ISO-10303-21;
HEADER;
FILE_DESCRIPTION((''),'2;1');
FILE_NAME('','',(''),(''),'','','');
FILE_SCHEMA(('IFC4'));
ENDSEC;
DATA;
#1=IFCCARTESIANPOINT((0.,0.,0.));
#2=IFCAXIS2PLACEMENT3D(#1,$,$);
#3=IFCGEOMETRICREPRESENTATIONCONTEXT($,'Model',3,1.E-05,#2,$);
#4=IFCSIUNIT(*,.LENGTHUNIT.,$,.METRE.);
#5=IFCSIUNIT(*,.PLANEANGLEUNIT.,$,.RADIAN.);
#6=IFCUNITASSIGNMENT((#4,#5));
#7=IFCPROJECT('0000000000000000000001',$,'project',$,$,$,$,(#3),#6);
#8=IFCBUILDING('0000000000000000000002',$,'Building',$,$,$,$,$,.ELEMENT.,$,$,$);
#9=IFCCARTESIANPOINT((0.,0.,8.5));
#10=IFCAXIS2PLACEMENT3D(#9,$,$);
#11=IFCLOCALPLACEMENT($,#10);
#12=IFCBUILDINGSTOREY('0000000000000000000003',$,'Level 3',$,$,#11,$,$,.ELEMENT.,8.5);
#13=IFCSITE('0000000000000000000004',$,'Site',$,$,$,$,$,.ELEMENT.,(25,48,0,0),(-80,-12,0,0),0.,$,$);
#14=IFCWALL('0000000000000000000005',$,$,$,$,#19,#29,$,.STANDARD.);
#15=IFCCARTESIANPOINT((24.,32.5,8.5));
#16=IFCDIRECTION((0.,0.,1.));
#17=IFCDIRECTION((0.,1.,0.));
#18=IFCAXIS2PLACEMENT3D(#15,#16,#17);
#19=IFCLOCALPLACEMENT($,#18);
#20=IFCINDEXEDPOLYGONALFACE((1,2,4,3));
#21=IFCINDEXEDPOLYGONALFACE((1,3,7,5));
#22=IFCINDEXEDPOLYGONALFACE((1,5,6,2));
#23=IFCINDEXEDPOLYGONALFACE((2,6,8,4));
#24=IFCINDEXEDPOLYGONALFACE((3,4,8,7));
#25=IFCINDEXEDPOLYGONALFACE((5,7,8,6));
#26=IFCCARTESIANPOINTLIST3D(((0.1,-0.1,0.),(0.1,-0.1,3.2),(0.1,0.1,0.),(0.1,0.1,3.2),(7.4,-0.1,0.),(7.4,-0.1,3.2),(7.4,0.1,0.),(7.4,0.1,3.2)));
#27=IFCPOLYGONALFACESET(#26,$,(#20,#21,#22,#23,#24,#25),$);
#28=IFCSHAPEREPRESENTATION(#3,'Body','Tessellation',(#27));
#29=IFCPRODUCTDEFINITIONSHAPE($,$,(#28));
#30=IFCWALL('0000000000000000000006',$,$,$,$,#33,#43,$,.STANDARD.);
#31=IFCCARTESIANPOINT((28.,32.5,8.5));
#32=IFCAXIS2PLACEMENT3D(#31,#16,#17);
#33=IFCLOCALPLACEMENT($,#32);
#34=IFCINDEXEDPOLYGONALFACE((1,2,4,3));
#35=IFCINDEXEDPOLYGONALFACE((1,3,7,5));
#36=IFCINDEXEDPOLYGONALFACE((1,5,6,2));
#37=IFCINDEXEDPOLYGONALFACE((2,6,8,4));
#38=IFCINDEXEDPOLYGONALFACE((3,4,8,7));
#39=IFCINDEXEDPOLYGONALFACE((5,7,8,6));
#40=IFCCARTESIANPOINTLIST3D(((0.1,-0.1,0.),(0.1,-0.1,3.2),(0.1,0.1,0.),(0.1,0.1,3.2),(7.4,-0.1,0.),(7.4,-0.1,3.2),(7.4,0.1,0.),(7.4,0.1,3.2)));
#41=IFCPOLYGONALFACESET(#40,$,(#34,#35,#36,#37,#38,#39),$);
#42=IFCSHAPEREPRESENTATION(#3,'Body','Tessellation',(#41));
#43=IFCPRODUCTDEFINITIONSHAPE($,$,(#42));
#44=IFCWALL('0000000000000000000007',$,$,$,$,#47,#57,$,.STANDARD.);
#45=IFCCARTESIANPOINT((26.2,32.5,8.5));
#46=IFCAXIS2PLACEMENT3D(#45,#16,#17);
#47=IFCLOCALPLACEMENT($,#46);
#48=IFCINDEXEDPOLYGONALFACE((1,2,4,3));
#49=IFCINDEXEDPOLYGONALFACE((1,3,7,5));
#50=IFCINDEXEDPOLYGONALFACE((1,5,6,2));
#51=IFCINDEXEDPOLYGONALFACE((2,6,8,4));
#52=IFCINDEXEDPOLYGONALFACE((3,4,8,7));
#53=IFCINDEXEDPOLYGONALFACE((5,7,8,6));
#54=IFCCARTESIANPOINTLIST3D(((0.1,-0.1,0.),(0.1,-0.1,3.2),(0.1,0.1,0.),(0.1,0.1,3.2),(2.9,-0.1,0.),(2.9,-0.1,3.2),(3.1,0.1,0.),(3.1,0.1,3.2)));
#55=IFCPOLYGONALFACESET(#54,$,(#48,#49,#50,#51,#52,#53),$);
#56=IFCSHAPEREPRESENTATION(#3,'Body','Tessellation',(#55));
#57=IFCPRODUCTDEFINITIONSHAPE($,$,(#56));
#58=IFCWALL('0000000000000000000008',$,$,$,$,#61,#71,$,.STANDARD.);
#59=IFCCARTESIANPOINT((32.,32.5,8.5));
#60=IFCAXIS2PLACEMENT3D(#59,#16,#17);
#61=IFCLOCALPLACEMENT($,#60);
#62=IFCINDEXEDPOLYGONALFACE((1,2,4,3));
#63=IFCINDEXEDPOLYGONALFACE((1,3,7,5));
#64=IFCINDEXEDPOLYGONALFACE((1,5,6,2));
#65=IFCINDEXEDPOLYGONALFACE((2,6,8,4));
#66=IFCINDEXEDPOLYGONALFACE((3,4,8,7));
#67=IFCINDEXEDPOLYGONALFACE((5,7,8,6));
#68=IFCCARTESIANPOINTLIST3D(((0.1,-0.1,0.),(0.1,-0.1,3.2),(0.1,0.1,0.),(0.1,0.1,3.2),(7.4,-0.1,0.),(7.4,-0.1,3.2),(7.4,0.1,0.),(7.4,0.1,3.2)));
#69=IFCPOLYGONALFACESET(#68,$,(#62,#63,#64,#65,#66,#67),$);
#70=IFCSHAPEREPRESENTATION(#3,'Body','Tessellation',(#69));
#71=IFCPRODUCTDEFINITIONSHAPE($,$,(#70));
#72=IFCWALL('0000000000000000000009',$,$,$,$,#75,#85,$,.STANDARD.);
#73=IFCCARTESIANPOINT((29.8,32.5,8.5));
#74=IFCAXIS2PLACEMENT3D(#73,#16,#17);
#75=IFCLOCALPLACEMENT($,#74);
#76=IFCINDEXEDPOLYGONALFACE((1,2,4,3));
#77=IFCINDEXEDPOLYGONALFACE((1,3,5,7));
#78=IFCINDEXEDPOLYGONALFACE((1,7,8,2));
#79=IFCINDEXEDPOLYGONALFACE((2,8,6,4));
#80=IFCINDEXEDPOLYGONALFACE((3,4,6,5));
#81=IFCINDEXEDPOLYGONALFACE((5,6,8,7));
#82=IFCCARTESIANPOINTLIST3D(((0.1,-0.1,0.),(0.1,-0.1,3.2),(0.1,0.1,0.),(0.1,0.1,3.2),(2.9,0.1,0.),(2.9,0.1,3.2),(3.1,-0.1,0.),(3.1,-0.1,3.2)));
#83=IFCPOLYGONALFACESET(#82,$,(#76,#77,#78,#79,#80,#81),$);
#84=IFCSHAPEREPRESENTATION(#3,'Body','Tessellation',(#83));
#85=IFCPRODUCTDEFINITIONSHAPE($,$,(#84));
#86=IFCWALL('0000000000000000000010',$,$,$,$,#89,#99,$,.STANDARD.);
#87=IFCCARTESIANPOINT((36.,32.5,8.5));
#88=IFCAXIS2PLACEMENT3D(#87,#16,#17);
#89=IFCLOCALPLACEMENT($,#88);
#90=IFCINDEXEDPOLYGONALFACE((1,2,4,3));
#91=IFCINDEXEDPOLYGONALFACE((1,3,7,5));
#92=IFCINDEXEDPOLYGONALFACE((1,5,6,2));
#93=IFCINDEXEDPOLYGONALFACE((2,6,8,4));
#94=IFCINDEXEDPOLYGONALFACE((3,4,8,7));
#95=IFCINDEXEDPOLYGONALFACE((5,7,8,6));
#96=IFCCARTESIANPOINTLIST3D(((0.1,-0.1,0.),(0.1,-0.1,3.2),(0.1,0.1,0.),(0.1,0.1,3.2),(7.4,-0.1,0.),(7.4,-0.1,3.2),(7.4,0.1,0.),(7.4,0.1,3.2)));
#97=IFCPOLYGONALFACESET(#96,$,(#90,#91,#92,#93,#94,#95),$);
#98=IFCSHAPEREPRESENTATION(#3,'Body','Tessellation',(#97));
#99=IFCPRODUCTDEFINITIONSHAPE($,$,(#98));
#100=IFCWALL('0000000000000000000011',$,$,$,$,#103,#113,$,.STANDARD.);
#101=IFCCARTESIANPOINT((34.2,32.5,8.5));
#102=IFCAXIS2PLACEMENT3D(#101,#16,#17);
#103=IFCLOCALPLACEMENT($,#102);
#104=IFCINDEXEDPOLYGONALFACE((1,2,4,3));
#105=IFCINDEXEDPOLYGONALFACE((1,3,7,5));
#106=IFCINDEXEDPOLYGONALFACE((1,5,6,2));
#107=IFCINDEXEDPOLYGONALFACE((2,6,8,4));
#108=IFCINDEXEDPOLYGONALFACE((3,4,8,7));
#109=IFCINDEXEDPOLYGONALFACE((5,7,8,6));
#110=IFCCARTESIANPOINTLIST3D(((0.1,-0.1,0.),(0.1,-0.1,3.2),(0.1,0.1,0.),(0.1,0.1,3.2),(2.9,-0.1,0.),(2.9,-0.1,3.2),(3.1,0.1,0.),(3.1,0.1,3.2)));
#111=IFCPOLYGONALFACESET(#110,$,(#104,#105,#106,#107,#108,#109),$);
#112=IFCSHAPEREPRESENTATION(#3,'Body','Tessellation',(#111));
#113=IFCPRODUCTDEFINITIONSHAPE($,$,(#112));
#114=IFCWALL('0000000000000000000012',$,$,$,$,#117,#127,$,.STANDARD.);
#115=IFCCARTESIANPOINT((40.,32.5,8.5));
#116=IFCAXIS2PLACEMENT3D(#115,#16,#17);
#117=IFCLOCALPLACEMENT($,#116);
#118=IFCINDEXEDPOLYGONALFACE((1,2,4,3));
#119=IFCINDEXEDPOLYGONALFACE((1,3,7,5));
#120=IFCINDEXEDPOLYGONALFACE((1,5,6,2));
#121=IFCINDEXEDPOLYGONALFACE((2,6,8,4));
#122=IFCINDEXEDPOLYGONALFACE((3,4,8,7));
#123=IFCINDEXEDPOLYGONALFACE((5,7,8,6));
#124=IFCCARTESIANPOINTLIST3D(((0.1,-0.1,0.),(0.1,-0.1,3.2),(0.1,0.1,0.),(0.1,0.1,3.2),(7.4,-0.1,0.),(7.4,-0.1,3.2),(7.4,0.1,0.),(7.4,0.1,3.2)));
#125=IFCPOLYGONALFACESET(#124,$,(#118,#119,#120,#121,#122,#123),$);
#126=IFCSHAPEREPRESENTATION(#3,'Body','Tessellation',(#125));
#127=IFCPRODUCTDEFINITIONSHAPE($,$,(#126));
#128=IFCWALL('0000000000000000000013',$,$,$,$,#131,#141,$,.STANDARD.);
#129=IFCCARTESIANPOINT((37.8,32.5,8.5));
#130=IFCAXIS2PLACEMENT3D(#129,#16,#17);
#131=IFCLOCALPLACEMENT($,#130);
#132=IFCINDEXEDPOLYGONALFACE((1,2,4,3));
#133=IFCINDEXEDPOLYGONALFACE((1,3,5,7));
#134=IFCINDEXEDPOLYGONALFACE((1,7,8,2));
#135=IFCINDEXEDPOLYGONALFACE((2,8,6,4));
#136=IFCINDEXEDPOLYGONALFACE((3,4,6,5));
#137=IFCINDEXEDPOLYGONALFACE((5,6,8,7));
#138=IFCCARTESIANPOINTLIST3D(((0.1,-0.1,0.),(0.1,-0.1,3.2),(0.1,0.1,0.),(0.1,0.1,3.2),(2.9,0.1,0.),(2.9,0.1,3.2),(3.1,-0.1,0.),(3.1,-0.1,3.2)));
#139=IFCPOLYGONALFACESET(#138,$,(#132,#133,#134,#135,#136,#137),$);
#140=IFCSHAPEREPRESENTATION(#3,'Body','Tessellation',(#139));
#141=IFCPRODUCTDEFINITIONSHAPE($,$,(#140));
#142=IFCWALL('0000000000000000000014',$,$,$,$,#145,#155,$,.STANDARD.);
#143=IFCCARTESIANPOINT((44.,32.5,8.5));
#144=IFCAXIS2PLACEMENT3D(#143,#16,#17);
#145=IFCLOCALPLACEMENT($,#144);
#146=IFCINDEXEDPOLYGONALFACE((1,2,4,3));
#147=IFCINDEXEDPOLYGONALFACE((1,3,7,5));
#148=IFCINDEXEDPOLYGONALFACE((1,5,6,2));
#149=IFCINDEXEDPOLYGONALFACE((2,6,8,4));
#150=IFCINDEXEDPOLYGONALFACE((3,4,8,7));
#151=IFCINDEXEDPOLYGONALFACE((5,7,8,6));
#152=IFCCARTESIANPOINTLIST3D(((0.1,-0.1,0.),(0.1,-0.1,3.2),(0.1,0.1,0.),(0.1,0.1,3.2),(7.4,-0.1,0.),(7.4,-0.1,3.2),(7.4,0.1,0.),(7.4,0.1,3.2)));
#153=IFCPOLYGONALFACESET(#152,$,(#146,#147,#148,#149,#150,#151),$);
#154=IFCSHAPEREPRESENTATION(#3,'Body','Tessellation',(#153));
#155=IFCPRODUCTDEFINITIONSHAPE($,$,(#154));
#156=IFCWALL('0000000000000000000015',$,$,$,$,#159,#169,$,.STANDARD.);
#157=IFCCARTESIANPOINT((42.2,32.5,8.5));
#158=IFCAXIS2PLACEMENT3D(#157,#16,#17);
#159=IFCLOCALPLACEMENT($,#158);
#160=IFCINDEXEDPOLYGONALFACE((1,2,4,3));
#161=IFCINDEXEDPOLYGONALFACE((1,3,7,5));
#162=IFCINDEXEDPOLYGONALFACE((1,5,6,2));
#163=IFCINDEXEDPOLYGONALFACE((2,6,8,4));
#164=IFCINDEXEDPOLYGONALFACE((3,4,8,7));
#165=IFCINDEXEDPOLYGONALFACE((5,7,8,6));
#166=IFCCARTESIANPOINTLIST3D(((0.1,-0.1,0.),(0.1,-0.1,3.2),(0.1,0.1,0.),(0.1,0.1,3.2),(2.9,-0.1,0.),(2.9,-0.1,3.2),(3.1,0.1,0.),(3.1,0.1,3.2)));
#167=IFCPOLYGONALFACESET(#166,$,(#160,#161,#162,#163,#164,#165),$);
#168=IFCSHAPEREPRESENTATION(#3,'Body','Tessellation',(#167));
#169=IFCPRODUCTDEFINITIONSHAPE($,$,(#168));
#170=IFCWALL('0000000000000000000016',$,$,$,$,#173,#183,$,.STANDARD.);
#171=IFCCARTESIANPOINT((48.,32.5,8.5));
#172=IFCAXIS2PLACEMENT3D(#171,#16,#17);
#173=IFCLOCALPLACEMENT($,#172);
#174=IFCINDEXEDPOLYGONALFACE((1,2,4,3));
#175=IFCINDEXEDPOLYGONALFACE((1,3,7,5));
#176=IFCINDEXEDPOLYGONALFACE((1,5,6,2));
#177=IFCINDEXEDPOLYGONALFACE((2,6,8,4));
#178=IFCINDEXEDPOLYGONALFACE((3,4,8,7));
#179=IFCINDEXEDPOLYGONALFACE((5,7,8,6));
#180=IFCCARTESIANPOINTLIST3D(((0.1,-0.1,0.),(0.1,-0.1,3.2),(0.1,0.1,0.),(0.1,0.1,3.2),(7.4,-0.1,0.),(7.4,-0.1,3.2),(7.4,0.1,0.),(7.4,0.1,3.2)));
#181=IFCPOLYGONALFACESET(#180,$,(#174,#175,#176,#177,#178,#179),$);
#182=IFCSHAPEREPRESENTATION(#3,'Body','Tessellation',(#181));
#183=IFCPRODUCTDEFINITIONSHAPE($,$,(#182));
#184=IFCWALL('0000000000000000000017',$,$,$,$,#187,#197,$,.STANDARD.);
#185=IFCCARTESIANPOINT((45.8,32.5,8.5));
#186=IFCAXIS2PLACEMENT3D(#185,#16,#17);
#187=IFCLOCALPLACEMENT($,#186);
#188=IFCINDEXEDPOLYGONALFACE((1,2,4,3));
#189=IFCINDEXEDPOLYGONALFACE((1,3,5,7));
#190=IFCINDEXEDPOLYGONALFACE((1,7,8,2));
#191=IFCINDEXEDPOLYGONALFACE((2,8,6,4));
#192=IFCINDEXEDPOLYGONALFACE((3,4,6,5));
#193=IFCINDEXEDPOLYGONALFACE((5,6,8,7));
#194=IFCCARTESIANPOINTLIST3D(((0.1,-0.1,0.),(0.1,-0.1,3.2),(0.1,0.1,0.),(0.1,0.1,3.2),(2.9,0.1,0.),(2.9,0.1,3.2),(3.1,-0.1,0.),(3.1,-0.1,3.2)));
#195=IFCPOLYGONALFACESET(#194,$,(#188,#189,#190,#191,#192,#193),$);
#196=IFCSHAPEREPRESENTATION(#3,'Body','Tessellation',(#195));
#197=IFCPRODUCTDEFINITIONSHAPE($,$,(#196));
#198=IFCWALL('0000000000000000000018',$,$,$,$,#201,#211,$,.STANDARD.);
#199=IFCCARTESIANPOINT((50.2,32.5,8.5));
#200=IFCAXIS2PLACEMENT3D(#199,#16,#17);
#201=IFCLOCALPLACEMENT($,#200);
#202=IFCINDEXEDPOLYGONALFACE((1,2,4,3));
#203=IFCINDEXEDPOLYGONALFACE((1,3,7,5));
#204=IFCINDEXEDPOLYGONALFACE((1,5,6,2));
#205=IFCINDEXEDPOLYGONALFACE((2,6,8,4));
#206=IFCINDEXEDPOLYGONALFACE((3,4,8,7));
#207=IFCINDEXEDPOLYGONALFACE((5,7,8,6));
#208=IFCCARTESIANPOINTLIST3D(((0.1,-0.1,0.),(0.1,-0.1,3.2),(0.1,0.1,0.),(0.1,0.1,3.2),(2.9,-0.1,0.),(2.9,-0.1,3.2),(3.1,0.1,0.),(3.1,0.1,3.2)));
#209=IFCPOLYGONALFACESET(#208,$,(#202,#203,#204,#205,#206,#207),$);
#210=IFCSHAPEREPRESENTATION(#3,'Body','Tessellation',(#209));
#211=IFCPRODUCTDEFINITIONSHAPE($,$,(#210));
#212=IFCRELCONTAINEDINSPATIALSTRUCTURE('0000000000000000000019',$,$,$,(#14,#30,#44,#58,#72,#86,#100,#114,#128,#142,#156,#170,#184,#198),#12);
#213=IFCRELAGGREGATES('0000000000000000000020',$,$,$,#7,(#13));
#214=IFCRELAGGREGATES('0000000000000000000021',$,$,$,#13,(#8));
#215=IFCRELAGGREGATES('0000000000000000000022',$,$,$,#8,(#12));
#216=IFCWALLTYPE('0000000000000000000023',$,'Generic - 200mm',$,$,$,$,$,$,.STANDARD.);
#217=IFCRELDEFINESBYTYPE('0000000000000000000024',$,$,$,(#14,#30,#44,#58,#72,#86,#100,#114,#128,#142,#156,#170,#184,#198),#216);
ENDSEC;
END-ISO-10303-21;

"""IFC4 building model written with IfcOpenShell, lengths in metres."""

from ifc_helpers import new_model, si_unit, frame, origin, place, context, project, spatial, polyline, outline, extrude, type_object, element, save


model = new_model("IFC4")

# Units and contexts
model_context = context("Model", 3, precision=1e-05, world=origin())
ifc_project = project(units=[si_unit("LENGTHUNIT", "METRE"), si_unit("PLANEANGLEUNIT", "RADIAN")], contexts=[model_context])

# Site, building, storey
site = spatial("IfcSite", under=ifc_project, Name="Site", CompositionType="ELEMENT", RefLatitude=(25, 48, 0, 0), RefLongitude=(-80, -12, 0, 0), RefElevation=0.0)
building = spatial("IfcBuilding", under=site, Name="Building", CompositionType="ELEMENT")
storey_placement = place(None, frame((0.0, 0.0, 8.5)))
storey = spatial("IfcBuildingStorey", under=building, at=storey_placement, Name="Level 3", CompositionType="ELEMENT", Elevation=8.5)

# Shared definitions
wall_type = type_object("IfcWallType", Name="Generic - 200mm", PredefinedType="STANDARD")

# Walls
for number, where, z_axis, x_axis in (
    (1, (24.0, 32.5, 8.5), (0.0, 0.0, 1.0), (0.0, 1.0, 0.0)),
    (2, (28.0, 32.5, 8.5), (0.0, 0.0, 1.0), (0.0, 1.0, 0.0)),
):
    element("IfcWall", number, at=place(None, frame(where, z_axis=z_axis, x_axis=x_axis)), inside=storey, type_object=wall_type, PredefinedType="STANDARD", context=model_context, shape_type="SweptSolid", body=[
        extrude(outline(polyline([(0.1, -0.1), (7.4, -0.1), (7.4, 0.1), (0.1, 0.1), (0.1, -0.1)])), origin(), (0.0, 0.0, 1.0), 3.2),
    ])
wall_1_placement = place(None, frame((26.2, 32.5, 8.5), z_axis=(0.0, 0.0, 1.0), x_axis=(0.0, 1.0, 0.0)))
element("IfcWall", 3, at=wall_1_placement, inside=storey, type_object=wall_type, PredefinedType="STANDARD", context=model_context, shape_type="SweptSolid", body=[
    extrude(outline(polyline([(0.1, -0.1), (2.9, -0.1), (3.1, 0.1), (0.1, 0.1), (0.1, -0.1)])), origin(), (0.0, 0.0, 1.0), 3.2),
])
wall_2_placement = place(None, frame((32.0, 32.5, 8.5), z_axis=(0.0, 0.0, 1.0), x_axis=(0.0, 1.0, 0.0)))
element("IfcWall", 4, at=wall_2_placement, inside=storey, type_object=wall_type, PredefinedType="STANDARD", context=model_context, shape_type="SweptSolid", body=[
    extrude(outline(polyline([(0.1, -0.1), (7.4, -0.1), (7.4, 0.1), (0.1, 0.1), (0.1, -0.1)])), origin(), (0.0, 0.0, 1.0), 3.2),
])
wall_3_placement = place(None, frame((29.8, 32.5, 8.5), z_axis=(0.0, 0.0, 1.0), x_axis=(0.0, 1.0, 0.0)))
element("IfcWall", 5, at=wall_3_placement, inside=storey, type_object=wall_type, PredefinedType="STANDARD", context=model_context, shape_type="SweptSolid", body=[
    extrude(outline(polyline([(0.1, -0.1), (3.1, -0.1), (2.9, 0.1), (0.1, 0.1), (0.1, -0.1)])), origin(), (0.0, 0.0, 1.0), 3.2),
])
wall_4_placement = place(None, frame((36.0, 32.5, 8.5), z_axis=(0.0, 0.0, 1.0), x_axis=(0.0, 1.0, 0.0)))
element("IfcWall", 6, at=wall_4_placement, inside=storey, type_object=wall_type, PredefinedType="STANDARD", context=model_context, shape_type="SweptSolid", body=[
    extrude(outline(polyline([(0.1, -0.1), (7.4, -0.1), (7.4, 0.1), (0.1, 0.1), (0.1, -0.1)])), origin(), (0.0, 0.0, 1.0), 3.2),
])
wall_5_placement = place(None, frame((34.2, 32.5, 8.5), z_axis=(0.0, 0.0, 1.0), x_axis=(0.0, 1.0, 0.0)))
element("IfcWall", 7, at=wall_5_placement, inside=storey, type_object=wall_type, PredefinedType="STANDARD", context=model_context, shape_type="SweptSolid", body=[
    extrude(outline(polyline([(0.1, -0.1), (2.9, -0.1), (3.1, 0.1), (0.1, 0.1), (0.1, -0.1)])), origin(), (0.0, 0.0, 1.0), 3.2),
])
wall_6_placement = place(None, frame((40.0, 32.5, 8.5), z_axis=(0.0, 0.0, 1.0), x_axis=(0.0, 1.0, 0.0)))
element("IfcWall", 8, at=wall_6_placement, inside=storey, type_object=wall_type, PredefinedType="STANDARD", context=model_context, shape_type="SweptSolid", body=[
    extrude(outline(polyline([(0.1, -0.1), (7.4, -0.1), (7.4, 0.1), (0.1, 0.1), (0.1, -0.1)])), origin(), (0.0, 0.0, 1.0), 3.2),
])
wall_7_placement = place(None, frame((37.8, 32.5, 8.5), z_axis=(0.0, 0.0, 1.0), x_axis=(0.0, 1.0, 0.0)))
element("IfcWall", 9, at=wall_7_placement, inside=storey, type_object=wall_type, PredefinedType="STANDARD", context=model_context, shape_type="SweptSolid", body=[
    extrude(outline(polyline([(0.1, -0.1), (3.1, -0.1), (2.9, 0.1), (0.1, 0.1), (0.1, -0.1)])), origin(), (0.0, 0.0, 1.0), 3.2),
])
wall_8_placement = place(None, frame((44.0, 32.5, 8.5), z_axis=(0.0, 0.0, 1.0), x_axis=(0.0, 1.0, 0.0)))
element("IfcWall", 10, at=wall_8_placement, inside=storey, type_object=wall_type, PredefinedType="STANDARD", context=model_context, shape_type="SweptSolid", body=[
    extrude(outline(polyline([(0.1, -0.1), (7.4, -0.1), (7.4, 0.1), (0.1, 0.1), (0.1, -0.1)])), origin(), (0.0, 0.0, 1.0), 3.2),
])
wall_9_placement = place(None, frame((42.2, 32.5, 8.5), z_axis=(0.0, 0.0, 1.0), x_axis=(0.0, 1.0, 0.0)))
element("IfcWall", 11, at=wall_9_placement, inside=storey, type_object=wall_type, PredefinedType="STANDARD", context=model_context, shape_type="SweptSolid", body=[
    extrude(outline(polyline([(0.1, -0.1), (2.9, -0.1), (3.1, 0.1), (0.1, 0.1), (0.1, -0.1)])), origin(), (0.0, 0.0, 1.0), 3.2),
])
wall_10_placement = place(None, frame((48.0, 32.5, 8.5), z_axis=(0.0, 0.0, 1.0), x_axis=(0.0, 1.0, 0.0)))
element("IfcWall", 12, at=wall_10_placement, inside=storey, type_object=wall_type, PredefinedType="STANDARD", context=model_context, shape_type="SweptSolid", body=[
    extrude(outline(polyline([(0.1, -0.1), (7.4, -0.1), (7.4, 0.1), (0.1, 0.1), (0.1, -0.1)])), origin(), (0.0, 0.0, 1.0), 3.2),
])
wall_11_placement = place(None, frame((45.8, 32.5, 8.5), z_axis=(0.0, 0.0, 1.0), x_axis=(0.0, 1.0, 0.0)))
element("IfcWall", 13, at=wall_11_placement, inside=storey, type_object=wall_type, PredefinedType="STANDARD", context=model_context, shape_type="SweptSolid", body=[
    extrude(outline(polyline([(0.1, -0.1), (3.1, -0.1), (2.9, 0.1), (0.1, 0.1), (0.1, -0.1)])), origin(), (0.0, 0.0, 1.0), 3.2),
])
wall_12_placement = place(None, frame((50.2, 32.5, 8.5), z_axis=(0.0, 0.0, 1.0), x_axis=(0.0, 1.0, 0.0)))
element("IfcWall", 14, at=wall_12_placement, inside=storey, type_object=wall_type, PredefinedType="STANDARD", context=model_context, shape_type="SweptSolid", body=[
    extrude(outline(polyline([(0.1, -0.1), (2.9, -0.1), (3.1, 0.1), (0.1, 0.1), (0.1, -0.1)])), origin(), (0.0, 0.0, 1.0), 3.2),
])

save(model, "model.ifc")
